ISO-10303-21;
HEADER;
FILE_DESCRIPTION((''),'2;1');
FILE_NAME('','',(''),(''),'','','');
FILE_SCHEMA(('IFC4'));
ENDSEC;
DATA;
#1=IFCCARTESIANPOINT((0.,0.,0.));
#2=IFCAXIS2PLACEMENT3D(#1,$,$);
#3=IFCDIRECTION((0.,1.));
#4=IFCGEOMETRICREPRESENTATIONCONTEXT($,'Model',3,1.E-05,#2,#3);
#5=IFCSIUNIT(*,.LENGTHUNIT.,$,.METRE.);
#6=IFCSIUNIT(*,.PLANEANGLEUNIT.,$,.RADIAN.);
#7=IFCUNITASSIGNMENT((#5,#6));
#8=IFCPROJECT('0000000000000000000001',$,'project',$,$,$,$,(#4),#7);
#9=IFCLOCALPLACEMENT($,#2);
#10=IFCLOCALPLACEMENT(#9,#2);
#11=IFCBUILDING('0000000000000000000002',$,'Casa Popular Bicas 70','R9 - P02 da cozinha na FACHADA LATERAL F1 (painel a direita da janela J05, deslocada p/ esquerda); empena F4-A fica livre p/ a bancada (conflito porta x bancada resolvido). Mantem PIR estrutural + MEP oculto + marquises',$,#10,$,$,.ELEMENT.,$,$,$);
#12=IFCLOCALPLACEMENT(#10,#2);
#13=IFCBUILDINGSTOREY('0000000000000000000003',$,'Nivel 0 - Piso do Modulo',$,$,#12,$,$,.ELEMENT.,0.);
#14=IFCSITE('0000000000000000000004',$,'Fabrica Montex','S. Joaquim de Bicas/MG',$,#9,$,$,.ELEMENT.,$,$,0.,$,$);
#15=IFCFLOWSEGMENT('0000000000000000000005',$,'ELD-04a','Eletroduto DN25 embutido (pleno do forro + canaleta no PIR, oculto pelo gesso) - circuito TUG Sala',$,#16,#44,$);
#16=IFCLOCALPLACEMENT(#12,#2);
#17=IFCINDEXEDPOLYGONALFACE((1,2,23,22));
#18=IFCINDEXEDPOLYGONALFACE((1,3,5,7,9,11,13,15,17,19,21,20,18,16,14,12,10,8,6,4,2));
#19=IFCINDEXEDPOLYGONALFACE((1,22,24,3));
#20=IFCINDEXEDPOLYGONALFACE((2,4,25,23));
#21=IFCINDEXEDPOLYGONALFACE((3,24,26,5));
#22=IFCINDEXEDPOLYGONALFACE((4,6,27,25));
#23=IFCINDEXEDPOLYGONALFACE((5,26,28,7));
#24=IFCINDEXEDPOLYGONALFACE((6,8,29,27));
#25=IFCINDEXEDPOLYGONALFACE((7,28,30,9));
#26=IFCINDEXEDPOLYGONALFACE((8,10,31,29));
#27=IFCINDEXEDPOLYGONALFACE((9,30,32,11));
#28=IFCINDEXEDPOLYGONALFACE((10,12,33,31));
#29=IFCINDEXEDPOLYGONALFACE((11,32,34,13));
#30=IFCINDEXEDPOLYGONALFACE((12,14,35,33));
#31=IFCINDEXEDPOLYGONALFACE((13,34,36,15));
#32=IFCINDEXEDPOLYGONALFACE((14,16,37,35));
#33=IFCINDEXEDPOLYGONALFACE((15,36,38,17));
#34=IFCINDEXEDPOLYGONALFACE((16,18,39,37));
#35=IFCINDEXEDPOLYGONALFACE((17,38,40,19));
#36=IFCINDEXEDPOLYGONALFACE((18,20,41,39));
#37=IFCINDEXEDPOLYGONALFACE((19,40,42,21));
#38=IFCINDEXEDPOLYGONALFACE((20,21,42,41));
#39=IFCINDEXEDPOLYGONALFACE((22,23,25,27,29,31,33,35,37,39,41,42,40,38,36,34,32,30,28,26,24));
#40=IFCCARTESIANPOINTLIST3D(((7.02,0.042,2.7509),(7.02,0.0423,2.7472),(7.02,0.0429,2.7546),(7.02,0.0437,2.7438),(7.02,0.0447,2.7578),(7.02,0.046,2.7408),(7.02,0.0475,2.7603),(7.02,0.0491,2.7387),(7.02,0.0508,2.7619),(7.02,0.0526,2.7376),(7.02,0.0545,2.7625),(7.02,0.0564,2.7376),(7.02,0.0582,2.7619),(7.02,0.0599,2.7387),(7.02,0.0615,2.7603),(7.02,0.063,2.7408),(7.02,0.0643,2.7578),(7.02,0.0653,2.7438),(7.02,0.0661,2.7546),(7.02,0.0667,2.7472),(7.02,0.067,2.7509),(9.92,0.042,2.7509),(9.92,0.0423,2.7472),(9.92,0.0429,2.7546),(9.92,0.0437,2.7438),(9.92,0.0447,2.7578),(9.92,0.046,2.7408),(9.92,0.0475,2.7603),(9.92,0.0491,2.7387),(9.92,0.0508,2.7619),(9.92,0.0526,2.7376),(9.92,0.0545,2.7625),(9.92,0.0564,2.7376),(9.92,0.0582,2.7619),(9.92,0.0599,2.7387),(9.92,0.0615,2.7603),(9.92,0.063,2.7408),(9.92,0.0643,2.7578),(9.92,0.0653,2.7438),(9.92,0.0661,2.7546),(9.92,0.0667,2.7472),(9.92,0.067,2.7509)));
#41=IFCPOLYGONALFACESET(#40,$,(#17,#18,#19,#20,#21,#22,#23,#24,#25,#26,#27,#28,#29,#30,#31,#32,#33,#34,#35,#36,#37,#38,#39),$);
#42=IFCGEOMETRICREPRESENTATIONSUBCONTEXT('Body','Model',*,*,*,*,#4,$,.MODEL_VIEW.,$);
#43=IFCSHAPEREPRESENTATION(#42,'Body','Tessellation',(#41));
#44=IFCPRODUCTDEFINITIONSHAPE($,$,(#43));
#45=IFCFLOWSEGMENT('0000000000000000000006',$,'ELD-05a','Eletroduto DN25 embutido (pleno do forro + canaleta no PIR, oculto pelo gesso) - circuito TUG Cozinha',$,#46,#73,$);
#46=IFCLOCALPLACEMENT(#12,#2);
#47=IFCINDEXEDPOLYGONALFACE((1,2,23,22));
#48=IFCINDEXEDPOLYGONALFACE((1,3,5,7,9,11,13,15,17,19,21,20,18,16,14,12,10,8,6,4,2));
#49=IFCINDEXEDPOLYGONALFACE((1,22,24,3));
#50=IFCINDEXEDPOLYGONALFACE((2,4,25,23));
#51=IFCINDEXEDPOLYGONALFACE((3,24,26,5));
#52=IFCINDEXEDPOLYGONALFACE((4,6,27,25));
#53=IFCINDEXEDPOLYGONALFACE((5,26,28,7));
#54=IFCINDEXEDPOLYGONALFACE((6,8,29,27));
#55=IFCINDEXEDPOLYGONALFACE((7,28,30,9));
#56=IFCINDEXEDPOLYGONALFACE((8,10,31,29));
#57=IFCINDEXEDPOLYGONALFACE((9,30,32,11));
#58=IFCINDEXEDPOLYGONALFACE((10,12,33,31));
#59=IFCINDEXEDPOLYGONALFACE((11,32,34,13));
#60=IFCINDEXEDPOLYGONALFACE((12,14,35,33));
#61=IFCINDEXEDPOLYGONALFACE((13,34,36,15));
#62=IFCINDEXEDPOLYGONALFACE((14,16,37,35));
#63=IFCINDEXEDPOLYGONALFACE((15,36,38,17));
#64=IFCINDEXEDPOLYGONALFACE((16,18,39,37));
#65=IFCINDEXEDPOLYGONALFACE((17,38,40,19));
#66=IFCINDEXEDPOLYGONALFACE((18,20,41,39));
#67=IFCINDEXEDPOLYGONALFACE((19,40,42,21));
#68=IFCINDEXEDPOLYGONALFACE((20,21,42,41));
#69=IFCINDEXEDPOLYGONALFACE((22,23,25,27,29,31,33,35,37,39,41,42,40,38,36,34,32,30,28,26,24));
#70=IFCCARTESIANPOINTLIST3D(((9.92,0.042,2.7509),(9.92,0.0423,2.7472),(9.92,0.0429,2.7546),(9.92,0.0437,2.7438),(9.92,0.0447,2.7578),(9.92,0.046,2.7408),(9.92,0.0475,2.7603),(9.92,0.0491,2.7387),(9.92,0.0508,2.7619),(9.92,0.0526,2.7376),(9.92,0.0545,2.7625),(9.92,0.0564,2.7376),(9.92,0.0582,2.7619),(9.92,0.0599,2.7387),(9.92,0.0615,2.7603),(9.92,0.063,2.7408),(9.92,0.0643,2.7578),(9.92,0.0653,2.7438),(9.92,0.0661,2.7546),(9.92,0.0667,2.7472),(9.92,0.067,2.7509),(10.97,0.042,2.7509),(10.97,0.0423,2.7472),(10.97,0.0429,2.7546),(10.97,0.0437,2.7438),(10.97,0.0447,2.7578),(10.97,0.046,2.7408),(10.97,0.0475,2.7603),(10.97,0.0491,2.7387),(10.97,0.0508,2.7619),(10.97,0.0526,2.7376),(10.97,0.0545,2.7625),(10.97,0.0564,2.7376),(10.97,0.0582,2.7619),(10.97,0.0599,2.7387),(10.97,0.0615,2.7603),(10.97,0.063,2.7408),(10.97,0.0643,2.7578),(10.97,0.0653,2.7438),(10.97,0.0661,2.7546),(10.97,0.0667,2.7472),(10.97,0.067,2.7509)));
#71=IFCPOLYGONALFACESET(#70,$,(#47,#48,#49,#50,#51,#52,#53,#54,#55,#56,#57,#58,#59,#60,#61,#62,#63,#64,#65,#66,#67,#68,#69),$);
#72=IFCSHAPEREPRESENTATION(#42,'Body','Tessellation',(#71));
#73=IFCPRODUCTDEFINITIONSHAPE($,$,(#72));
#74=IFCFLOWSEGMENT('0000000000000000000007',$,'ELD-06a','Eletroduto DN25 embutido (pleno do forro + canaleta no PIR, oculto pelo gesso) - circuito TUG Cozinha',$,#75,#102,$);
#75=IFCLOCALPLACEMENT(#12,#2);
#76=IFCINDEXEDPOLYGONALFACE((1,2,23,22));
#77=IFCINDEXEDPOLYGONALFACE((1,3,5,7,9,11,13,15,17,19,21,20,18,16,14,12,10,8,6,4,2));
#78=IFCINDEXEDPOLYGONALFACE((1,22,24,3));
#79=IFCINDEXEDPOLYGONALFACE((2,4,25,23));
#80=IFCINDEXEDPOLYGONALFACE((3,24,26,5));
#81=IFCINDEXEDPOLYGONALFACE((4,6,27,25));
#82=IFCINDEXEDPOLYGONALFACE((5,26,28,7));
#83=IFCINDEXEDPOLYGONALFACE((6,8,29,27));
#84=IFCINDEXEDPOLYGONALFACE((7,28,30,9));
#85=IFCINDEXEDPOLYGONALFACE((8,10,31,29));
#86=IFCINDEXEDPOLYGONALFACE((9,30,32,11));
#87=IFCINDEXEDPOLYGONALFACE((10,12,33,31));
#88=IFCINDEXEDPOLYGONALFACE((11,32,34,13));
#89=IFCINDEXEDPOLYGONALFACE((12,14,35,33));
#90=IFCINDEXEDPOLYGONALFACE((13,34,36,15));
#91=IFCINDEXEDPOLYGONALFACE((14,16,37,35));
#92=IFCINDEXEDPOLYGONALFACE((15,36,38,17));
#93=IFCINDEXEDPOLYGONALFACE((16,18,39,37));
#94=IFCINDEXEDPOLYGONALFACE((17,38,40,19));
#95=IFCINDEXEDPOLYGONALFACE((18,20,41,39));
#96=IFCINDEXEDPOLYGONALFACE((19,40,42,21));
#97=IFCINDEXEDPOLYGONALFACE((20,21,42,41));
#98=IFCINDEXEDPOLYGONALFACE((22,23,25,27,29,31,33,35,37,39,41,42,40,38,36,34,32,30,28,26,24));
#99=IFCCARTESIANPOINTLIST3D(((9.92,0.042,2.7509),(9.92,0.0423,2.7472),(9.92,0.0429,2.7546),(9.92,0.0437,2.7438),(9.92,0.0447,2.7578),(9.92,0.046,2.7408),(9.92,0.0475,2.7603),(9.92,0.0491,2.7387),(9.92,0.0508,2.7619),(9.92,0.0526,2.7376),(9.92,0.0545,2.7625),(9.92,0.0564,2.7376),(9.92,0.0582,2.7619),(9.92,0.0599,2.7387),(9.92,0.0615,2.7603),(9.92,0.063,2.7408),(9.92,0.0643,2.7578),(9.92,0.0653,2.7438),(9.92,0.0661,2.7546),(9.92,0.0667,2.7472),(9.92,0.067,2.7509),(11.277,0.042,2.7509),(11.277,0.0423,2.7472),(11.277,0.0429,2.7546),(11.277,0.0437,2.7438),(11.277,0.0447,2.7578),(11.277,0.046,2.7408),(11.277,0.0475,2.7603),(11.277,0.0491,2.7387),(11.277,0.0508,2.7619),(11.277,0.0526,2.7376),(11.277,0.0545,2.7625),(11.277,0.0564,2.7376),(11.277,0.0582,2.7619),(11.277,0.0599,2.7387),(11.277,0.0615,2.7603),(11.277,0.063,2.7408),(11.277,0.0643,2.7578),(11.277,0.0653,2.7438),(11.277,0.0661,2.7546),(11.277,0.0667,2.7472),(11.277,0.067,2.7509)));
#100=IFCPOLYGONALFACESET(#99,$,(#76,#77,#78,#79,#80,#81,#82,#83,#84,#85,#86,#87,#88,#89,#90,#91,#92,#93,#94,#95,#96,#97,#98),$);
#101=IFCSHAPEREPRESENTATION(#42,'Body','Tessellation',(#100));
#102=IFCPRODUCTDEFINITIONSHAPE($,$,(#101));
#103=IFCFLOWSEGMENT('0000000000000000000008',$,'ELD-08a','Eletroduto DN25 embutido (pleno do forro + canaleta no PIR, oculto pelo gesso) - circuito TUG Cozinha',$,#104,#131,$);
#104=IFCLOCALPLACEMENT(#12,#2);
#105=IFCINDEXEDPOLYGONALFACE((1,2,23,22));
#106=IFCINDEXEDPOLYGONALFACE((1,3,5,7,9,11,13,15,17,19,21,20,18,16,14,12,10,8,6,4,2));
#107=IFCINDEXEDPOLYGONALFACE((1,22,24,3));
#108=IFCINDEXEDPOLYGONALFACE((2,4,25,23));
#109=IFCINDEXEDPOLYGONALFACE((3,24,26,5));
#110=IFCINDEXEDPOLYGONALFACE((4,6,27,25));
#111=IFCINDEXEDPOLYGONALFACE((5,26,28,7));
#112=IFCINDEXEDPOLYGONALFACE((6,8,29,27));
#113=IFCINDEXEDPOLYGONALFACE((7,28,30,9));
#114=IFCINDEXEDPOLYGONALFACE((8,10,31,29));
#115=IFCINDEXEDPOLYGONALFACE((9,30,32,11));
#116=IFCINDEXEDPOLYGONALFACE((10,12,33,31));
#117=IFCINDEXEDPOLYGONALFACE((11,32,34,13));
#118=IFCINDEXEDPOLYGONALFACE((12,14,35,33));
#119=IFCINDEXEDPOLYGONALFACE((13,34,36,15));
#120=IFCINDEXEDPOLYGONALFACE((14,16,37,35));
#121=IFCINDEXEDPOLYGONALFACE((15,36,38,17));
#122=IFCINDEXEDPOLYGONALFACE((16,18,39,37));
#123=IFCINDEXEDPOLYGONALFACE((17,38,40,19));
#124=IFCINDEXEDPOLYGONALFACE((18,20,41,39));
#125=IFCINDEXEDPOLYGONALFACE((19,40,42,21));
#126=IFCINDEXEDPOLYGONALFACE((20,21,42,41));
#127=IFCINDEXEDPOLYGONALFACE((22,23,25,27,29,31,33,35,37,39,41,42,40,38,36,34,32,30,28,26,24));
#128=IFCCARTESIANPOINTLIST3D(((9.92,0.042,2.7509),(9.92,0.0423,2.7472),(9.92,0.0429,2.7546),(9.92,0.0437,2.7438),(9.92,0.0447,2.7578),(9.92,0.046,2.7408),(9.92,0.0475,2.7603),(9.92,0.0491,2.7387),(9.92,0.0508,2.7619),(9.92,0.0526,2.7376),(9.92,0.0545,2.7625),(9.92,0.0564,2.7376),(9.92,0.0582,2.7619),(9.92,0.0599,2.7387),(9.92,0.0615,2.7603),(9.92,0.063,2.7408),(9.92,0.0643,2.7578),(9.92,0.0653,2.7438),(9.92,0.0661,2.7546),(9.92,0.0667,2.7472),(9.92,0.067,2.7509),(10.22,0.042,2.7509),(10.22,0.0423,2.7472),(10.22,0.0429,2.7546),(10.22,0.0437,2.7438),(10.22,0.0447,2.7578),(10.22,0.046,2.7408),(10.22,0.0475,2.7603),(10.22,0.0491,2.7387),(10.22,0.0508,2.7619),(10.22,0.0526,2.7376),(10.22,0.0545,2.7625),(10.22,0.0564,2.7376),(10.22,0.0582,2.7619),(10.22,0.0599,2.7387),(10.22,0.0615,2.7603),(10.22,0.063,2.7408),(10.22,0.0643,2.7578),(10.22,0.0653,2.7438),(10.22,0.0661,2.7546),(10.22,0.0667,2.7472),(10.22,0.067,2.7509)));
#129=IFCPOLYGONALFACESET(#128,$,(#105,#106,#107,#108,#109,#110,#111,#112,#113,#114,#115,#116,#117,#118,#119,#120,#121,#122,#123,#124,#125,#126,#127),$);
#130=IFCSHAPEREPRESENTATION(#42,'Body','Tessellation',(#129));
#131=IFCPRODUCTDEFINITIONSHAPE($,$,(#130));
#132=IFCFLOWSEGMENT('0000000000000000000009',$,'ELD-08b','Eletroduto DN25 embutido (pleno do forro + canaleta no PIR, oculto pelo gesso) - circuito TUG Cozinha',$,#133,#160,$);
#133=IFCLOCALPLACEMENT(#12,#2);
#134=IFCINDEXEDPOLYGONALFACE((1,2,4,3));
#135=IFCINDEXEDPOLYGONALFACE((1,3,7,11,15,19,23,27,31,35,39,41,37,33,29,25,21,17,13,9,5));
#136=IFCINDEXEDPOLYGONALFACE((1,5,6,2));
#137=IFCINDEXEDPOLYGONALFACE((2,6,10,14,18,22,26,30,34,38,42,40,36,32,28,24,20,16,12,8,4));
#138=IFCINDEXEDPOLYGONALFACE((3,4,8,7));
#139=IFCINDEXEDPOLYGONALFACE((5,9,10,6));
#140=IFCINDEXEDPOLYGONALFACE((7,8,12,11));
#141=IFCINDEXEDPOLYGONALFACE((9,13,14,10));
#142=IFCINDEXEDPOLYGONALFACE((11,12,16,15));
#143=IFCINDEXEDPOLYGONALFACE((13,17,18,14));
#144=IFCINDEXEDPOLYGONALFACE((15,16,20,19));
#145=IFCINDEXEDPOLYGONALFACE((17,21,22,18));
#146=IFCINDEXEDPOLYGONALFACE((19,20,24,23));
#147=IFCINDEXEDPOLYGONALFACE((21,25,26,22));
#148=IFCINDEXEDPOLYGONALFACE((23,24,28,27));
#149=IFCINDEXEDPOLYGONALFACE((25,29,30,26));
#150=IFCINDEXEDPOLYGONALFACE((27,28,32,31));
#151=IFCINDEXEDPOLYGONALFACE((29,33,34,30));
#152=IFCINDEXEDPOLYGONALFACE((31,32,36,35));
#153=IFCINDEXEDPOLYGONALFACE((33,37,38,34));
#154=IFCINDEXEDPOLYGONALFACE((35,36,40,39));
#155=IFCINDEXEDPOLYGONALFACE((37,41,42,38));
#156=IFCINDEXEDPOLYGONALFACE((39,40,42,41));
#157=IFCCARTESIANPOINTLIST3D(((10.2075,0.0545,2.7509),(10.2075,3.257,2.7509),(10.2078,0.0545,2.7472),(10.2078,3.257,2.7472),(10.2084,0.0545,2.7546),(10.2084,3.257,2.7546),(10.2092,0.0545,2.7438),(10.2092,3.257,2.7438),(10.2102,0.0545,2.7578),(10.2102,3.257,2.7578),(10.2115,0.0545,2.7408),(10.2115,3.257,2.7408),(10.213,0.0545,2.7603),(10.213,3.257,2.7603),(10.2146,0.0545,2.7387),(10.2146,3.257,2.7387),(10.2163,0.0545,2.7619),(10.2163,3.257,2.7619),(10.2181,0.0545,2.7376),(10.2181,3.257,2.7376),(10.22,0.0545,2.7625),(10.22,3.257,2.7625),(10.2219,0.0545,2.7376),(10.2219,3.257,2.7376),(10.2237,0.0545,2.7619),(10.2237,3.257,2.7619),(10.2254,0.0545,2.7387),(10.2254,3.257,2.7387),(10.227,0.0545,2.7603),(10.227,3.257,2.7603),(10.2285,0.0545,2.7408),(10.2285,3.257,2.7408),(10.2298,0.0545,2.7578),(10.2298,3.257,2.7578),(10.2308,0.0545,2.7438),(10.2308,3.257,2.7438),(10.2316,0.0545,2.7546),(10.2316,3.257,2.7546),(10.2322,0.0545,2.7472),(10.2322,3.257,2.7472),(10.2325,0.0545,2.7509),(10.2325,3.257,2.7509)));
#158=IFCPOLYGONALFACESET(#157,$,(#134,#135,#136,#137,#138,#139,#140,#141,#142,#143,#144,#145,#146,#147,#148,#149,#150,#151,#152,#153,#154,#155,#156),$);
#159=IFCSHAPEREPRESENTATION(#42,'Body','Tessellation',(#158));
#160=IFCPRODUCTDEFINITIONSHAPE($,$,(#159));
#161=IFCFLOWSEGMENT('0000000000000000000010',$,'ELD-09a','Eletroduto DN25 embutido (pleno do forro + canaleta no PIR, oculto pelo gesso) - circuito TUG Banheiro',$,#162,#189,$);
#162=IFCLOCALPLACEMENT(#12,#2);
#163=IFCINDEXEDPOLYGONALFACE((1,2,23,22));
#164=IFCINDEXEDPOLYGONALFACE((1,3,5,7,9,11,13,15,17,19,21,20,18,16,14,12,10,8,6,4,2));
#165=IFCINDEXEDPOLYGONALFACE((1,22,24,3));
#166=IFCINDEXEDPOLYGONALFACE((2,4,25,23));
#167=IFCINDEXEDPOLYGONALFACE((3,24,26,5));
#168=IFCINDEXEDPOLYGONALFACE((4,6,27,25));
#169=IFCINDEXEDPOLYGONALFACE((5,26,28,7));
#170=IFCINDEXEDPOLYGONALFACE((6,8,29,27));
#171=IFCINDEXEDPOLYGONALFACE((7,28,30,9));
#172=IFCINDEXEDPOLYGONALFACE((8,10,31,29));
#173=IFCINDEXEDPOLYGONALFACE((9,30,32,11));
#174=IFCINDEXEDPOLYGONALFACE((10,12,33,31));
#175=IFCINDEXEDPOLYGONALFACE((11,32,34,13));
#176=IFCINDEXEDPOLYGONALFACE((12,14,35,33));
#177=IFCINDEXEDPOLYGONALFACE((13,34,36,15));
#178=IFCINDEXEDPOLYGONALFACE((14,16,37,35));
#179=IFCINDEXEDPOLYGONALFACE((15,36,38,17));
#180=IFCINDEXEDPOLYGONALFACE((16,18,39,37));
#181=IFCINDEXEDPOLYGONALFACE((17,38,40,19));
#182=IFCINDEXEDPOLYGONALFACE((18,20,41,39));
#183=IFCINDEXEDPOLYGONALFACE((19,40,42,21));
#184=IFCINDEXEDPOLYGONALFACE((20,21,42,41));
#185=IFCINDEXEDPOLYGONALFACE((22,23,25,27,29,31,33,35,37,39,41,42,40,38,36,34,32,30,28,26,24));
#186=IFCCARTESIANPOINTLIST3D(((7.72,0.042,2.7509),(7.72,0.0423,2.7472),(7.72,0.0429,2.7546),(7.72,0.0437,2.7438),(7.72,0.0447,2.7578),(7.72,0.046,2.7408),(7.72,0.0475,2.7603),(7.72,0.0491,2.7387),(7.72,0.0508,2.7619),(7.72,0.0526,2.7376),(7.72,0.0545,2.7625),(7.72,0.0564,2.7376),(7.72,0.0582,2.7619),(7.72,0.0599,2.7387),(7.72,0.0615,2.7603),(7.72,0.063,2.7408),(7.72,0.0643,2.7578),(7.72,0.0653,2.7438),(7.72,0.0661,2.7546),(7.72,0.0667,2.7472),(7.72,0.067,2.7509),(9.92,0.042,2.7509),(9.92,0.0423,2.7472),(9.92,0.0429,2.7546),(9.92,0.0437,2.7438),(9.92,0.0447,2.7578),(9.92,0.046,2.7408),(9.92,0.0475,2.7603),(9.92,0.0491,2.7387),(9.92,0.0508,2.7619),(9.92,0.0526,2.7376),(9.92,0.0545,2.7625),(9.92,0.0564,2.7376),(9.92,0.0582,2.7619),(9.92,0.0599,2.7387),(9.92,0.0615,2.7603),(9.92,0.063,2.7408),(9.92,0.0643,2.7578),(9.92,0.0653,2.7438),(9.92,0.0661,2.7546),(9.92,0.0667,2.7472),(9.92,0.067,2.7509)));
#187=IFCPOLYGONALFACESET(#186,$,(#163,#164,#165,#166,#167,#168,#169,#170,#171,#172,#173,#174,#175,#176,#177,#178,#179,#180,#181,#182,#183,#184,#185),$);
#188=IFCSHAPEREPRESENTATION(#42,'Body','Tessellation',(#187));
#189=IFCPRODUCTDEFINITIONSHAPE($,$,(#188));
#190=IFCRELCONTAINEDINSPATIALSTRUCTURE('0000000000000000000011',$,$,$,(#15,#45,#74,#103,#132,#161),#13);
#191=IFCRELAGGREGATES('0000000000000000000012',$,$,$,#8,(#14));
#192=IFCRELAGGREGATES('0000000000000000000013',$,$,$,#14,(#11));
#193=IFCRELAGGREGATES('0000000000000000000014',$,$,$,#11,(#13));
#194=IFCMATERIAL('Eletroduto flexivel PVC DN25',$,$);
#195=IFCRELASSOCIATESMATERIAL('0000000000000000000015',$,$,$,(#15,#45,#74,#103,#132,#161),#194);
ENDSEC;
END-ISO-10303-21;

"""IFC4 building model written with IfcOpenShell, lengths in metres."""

from ifc_helpers import new_model, si_unit, direction, frame, origin, origin_2d, place, context, subcontext, project, spatial, circle, extrude, material, element, save


model = new_model("IFC4")

# Units and contexts
model_context = context("Model", 3, precision=1e-05, world=origin(), true_north=direction((0.0, 1.0)))
body_context = subcontext(model_context, "Body", "Model", "MODEL_VIEW")
ifc_project = project(units=[si_unit("LENGTHUNIT", "METRE"), si_unit("PLANEANGLEUNIT", "RADIAN")], contexts=[model_context])

# Site, building, storey
site_placement = place(None, origin())
site = spatial("IfcSite", under=ifc_project, at=site_placement, Name="Fabrica Montex", Description="S. Joaquim de Bicas/MG", CompositionType="ELEMENT", RefElevation=0.0)
building_placement = place(site_placement, origin())
building = spatial("IfcBuilding", under=site, at=building_placement, Name="Casa Popular Bicas 70", Description="R9 - P02 da cozinha na FACHADA LATERAL F1 (painel a direita da janela J05, deslocada p/ esquerda); empena F4-A fica livre p/ a bancada (conflito porta x bancada resolvido). Mantem PIR estrutural + MEP oculto + marquises", CompositionType="ELEMENT")
storey_placement = place(building_placement, origin())
storey = spatial("IfcBuildingStorey", under=building, at=storey_placement, Name="Nivel 0 - Piso do Modulo", CompositionType="ELEMENT", Elevation=0.0)

# Flow segments
ifc_material_1 = material(Name="Eletroduto flexivel PVC DN25")
flow_segment_1_placement = place(None, frame((9.92, 0.0545, 2.75), z_axis=(-1.0, 0.0, 0.0), x_axis=(0.0, 0.0, 1.0)))
element("IfcFlowSegment", 1, at=flow_segment_1_placement, inside=storey, material=ifc_material_1, Name="ELD-04a", Description="Eletroduto DN25 embutido (pleno do forro + canaleta no PIR, oculto pelo gesso) - circuito TUG Sala", context=body_context, shape_type="SweptSolid", body=[
    extrude(circle(Radius=0.0125, at=origin_2d()), origin(), (0.0, 0.0, 1.0), 2.9),
])
flow_segment_2_placement = place(None, frame((9.92, 0.0545, 2.75), z_axis=(1.0, 0.0, 0.0), x_axis=(0.0, 0.0, 1.0)))
element("IfcFlowSegment", 2, at=flow_segment_2_placement, inside=storey, material=ifc_material_1, Name="ELD-05a", Description="Eletroduto DN25 embutido (pleno do forro + canaleta no PIR, oculto pelo gesso) - circuito TUG Cozinha", context=body_context, shape_type="SweptSolid", body=[
    extrude(circle(Radius=0.0125, at=origin_2d()), origin(), (0.0, 0.0, 1.0), 1.05),
])
for number, where, z_axis, x_axis, name in (
    (3, (9.92, 0.0545, 2.75), (1.0, 0.0, 0.0), (0.0, 0.0, 1.0), "ELD-06a"),
):
    element("IfcFlowSegment", number, at=place(None, frame(where, z_axis=z_axis, x_axis=x_axis)), inside=storey, material=ifc_material_1, Name=name, Description="Eletroduto DN25 embutido (pleno do forro + canaleta no PIR, oculto pelo gesso) - circuito TUG Cozinha", context=body_context, shape_type="SweptSolid", body=[
        extrude(circle(Radius=0.0125, at=origin_2d()), origin(), (0.0, 0.0, 1.0), 1.357),
    ])
flow_segment_3_placement = place(None, frame((9.92, 0.0545, 2.75), z_axis=(1.0, 0.0, 0.0), x_axis=(0.0, 0.0, 1.0)))
element("IfcFlowSegment", 4, at=flow_segment_3_placement, inside=storey, material=ifc_material_1, Name="ELD-08a", Description="Eletroduto DN25 embutido (pleno do forro + canaleta no PIR, oculto pelo gesso) - circuito TUG Cozinha", context=body_context, shape_type="SweptSolid", body=[
    extrude(circle(Radius=0.0125, at=origin_2d()), origin(), (0.0, 0.0, 1.0), 0.3),
])
flow_segment_4_placement = place(None, frame((10.22, 0.0545, 2.75), z_axis=(0.0, 1.0, 0.0), x_axis=(0.0, 0.0, 1.0)))
element("IfcFlowSegment", 5, at=flow_segment_4_placement, inside=storey, material=ifc_material_1, Name="ELD-08b", Description="Eletroduto DN25 embutido (pleno do forro + canaleta no PIR, oculto pelo gesso) - circuito TUG Cozinha", context=body_context, shape_type="SweptSolid", body=[
    extrude(circle(Radius=0.0125, at=origin_2d()), origin(), (0.0, 0.0, 1.0), 3.2025),
])
flow_segment_5_placement = place(None, frame((9.92, 0.0545, 2.75), z_axis=(-1.0, 0.0, 0.0), x_axis=(0.0, 0.0, 1.0)))
element("IfcFlowSegment", 6, at=flow_segment_5_placement, inside=storey, material=ifc_material_1, Name="ELD-09a", Description="Eletroduto DN25 embutido (pleno do forro + canaleta no PIR, oculto pelo gesso) - circuito TUG Banheiro", context=body_context, shape_type="SweptSolid", body=[
    extrude(circle(Radius=0.0125, at=origin_2d()), origin(), (0.0, 0.0, 1.0), 2.2),
])

save(model, "model.ifc")
